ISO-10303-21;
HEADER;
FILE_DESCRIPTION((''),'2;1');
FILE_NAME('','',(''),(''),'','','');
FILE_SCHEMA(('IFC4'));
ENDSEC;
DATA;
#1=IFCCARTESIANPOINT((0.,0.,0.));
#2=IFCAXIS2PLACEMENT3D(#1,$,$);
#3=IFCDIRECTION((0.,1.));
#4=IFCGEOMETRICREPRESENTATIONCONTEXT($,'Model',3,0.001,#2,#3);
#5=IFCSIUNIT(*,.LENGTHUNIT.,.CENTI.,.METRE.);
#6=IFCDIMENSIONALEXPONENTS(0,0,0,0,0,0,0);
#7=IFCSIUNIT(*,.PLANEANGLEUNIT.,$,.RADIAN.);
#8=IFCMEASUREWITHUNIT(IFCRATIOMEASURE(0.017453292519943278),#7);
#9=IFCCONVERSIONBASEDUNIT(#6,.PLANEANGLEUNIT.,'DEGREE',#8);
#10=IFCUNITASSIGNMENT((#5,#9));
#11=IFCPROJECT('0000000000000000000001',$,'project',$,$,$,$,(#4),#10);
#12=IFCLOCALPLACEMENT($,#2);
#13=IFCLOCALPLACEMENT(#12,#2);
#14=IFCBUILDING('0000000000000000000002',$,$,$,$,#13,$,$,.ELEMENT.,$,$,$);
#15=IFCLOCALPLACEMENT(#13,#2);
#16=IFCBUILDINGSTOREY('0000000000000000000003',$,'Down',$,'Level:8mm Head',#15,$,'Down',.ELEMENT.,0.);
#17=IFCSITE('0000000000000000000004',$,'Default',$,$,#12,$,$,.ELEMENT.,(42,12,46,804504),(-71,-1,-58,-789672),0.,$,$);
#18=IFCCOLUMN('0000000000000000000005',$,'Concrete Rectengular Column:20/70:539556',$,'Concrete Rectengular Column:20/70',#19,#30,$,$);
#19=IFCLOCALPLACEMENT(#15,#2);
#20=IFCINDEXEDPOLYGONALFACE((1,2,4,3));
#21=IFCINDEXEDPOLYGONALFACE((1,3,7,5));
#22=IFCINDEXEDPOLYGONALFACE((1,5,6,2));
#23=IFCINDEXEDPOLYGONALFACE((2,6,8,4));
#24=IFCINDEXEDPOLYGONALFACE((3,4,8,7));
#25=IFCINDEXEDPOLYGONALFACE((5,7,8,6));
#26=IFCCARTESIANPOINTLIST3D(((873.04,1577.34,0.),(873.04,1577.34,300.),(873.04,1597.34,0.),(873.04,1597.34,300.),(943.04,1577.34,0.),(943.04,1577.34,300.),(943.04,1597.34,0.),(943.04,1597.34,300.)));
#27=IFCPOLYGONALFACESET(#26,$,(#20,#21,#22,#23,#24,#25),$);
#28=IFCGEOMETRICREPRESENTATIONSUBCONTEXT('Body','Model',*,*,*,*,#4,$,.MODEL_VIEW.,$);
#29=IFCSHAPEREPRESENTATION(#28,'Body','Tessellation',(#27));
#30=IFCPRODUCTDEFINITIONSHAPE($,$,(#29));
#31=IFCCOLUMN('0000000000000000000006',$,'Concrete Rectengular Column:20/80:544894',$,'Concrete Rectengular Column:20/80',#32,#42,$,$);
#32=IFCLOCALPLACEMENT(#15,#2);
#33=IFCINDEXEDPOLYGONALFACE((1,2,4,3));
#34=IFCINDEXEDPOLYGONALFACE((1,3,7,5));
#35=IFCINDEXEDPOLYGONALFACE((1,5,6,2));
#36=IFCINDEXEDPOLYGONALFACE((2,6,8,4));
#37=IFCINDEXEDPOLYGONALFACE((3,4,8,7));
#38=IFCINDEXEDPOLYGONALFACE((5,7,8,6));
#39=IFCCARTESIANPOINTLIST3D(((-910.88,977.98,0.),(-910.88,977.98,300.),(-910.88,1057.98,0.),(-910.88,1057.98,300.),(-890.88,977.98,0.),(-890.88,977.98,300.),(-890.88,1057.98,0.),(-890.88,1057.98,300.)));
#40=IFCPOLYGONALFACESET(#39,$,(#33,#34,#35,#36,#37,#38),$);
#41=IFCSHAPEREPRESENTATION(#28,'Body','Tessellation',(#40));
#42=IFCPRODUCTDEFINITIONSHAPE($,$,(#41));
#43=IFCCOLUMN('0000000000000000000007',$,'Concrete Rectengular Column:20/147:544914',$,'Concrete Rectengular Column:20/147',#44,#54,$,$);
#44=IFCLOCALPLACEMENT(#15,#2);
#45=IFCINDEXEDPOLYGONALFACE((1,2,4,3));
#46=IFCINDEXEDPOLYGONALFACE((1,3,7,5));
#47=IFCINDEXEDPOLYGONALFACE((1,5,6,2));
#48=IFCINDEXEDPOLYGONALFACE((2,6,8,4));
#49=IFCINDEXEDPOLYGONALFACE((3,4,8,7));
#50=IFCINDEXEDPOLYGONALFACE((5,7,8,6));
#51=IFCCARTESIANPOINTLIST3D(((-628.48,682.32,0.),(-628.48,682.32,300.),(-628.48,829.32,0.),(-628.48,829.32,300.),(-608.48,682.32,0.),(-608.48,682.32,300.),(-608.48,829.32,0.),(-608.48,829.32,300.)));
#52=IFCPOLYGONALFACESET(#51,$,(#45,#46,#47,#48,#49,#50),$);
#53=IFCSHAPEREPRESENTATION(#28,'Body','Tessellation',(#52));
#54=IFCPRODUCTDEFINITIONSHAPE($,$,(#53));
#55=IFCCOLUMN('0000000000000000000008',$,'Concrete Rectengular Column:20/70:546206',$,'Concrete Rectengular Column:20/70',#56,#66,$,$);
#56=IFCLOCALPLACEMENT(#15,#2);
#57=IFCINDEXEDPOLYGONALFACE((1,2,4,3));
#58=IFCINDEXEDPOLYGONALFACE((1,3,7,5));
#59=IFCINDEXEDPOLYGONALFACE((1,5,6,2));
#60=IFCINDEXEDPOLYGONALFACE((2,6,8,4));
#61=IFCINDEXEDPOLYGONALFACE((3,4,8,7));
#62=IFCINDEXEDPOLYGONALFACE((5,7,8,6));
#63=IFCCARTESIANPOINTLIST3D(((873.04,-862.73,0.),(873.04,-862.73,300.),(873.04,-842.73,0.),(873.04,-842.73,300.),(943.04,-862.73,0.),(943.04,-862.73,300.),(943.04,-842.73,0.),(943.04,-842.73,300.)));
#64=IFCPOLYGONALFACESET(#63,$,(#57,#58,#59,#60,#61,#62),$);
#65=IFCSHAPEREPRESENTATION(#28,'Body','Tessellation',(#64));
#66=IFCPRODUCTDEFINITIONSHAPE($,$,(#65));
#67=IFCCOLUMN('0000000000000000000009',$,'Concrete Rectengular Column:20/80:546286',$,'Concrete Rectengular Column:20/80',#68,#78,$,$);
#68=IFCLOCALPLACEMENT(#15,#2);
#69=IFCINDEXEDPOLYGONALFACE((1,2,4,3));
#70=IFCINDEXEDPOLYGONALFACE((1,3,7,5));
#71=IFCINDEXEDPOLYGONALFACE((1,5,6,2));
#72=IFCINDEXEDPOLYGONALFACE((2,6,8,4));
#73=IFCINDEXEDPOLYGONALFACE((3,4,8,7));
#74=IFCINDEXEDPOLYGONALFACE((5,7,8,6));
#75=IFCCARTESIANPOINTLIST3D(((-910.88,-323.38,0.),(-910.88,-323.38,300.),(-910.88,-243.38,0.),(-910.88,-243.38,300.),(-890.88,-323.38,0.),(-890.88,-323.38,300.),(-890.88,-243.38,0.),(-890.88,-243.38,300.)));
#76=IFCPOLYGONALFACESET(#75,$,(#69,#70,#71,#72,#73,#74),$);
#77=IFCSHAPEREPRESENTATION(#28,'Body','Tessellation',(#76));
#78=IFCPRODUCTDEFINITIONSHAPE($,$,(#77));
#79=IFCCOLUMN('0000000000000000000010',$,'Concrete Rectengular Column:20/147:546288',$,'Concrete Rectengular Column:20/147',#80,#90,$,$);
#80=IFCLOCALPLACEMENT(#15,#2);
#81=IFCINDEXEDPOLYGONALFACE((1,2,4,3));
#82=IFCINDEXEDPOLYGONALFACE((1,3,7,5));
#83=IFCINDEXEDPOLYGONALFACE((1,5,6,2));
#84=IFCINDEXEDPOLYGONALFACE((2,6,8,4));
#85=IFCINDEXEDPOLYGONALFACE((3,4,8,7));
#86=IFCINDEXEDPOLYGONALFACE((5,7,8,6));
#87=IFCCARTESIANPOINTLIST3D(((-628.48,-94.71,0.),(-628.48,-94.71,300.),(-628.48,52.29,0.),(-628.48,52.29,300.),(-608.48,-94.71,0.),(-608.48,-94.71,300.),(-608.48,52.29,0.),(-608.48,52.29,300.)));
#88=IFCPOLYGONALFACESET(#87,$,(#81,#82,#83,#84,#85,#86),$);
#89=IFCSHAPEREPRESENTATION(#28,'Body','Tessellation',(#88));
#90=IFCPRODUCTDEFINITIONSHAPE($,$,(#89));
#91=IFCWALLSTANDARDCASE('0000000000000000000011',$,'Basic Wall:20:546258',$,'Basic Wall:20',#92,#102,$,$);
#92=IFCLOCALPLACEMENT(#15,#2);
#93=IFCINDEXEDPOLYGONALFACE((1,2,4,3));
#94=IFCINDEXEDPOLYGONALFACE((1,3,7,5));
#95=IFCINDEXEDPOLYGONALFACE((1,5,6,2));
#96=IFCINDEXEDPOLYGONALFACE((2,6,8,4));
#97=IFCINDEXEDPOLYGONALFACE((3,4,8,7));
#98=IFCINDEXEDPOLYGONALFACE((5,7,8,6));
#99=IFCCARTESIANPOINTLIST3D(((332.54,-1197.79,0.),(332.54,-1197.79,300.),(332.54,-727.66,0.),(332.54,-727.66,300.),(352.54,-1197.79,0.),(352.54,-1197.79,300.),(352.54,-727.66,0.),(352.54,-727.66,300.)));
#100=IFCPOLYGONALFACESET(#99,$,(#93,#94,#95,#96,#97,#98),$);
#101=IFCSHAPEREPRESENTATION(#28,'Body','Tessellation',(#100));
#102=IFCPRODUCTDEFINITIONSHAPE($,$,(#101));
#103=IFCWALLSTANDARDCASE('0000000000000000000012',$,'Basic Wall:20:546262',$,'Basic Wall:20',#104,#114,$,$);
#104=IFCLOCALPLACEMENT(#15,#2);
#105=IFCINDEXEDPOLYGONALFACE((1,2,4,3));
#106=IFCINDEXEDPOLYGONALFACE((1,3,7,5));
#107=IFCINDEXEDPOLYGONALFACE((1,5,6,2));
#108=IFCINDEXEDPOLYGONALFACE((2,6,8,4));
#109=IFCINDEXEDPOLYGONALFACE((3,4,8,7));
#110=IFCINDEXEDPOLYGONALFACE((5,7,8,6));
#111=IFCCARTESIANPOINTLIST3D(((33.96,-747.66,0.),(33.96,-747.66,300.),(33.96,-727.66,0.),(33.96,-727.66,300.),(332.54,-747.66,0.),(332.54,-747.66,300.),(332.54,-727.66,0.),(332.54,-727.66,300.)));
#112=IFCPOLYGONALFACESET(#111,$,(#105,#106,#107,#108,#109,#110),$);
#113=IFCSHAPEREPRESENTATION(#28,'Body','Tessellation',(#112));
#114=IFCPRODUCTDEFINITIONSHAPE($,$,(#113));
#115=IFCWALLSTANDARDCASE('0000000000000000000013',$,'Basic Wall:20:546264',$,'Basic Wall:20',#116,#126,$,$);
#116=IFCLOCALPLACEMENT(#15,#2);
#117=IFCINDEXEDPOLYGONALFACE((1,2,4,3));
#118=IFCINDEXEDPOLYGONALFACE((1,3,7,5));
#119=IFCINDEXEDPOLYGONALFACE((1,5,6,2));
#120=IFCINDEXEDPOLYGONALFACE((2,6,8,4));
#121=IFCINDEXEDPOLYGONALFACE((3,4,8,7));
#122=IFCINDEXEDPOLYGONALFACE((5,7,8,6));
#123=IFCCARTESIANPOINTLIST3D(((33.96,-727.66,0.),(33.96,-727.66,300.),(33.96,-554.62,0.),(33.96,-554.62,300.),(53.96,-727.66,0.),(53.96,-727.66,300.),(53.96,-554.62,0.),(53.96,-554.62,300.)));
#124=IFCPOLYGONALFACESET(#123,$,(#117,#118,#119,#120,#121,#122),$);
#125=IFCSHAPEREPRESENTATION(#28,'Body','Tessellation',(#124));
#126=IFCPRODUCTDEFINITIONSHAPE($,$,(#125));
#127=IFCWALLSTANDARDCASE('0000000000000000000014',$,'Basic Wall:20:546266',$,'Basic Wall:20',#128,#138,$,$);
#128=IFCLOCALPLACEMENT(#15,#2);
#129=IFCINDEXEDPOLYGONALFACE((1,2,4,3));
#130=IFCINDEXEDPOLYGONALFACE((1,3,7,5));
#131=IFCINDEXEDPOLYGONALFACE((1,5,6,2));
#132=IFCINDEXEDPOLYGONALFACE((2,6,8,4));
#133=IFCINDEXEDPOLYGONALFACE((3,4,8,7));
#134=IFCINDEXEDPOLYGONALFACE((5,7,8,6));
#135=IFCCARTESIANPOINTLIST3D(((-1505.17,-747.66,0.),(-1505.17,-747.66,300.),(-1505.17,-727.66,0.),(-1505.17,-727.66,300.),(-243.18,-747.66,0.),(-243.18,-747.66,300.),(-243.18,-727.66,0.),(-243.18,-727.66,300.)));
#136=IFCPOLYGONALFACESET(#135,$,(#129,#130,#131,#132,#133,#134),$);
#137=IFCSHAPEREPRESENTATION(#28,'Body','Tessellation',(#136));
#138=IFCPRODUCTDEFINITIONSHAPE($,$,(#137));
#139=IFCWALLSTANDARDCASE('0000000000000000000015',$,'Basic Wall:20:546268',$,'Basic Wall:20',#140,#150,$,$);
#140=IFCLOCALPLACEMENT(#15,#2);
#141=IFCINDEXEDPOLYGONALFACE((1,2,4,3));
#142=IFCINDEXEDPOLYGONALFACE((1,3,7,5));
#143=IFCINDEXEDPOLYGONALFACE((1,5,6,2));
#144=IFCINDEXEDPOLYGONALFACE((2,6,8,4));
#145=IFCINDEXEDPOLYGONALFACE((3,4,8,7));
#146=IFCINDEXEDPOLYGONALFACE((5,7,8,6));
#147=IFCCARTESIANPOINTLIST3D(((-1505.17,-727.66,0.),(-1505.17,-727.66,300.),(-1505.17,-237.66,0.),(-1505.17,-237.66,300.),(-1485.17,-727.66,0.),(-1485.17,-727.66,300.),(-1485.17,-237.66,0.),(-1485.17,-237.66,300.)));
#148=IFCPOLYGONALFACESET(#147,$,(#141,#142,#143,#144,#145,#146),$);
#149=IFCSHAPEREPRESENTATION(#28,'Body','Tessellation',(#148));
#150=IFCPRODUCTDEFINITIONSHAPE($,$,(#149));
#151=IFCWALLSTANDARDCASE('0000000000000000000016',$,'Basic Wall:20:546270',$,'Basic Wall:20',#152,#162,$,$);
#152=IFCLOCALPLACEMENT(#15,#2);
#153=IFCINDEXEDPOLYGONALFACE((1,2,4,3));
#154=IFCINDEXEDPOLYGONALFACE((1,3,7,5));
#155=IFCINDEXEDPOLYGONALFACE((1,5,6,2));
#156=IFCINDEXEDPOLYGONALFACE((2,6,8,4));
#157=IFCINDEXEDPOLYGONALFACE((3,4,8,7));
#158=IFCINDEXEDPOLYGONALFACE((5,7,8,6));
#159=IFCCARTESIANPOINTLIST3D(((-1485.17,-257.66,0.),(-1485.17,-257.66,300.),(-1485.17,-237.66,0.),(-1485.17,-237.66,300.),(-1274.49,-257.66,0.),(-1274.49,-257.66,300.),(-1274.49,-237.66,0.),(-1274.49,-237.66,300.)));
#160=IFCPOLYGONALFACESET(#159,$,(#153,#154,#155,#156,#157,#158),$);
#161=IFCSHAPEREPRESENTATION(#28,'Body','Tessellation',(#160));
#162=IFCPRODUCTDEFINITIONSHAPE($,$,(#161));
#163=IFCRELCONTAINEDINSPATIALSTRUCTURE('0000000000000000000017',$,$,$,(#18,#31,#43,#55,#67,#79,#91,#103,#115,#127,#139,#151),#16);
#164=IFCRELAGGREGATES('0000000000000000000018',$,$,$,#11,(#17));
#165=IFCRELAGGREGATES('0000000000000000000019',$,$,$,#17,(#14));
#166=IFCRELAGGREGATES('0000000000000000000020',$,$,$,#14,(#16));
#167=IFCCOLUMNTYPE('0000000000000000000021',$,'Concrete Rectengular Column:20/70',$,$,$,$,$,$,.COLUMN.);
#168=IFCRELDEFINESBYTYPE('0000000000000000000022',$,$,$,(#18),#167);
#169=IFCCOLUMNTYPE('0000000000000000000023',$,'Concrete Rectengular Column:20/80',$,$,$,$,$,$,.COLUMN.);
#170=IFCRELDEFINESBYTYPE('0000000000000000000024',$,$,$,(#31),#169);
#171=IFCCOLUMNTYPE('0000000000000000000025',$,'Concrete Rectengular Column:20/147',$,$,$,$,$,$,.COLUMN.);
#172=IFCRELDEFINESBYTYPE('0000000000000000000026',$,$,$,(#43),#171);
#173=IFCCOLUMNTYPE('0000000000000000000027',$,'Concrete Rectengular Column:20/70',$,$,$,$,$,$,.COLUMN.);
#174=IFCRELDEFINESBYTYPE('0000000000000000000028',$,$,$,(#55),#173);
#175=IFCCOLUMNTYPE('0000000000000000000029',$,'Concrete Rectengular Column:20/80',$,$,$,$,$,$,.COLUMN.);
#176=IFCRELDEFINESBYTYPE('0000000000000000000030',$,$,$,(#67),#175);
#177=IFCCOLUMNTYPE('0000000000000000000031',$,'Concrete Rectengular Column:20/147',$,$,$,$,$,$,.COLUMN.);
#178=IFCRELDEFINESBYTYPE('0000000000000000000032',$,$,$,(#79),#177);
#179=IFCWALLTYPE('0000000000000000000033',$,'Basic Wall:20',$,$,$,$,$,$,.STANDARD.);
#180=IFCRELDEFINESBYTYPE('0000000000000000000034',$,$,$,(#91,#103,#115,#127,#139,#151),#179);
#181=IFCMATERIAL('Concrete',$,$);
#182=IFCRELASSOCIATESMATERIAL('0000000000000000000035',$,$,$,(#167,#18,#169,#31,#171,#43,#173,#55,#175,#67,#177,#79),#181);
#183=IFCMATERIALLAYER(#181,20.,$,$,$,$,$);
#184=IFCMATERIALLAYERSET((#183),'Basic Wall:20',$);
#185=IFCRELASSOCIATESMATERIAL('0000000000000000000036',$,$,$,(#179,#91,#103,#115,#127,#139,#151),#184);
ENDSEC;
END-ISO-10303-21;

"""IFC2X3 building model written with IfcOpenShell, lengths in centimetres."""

from ifc_helpers import new_model, entity, si_unit, converted_unit, direction, frame, frame_2d, origin, origin_2d_with_axis, place, context, subcontext, project, spatial, polyline, rectangle, extrude, clip, bounded_halfspace, source, transform, mapped, material, layer, layer_set, layer_usage, type_object, type_shapes, element, save


model = new_model("IFC2X3")

# Units and contexts
model_context = context("Model", 3, precision=0.001, world=origin(), true_north=direction((0.0, 1.0)))
body_context = subcontext(model_context, "Body", "Model", "MODEL_VIEW")
ifc_project = project(units=[si_unit("LENGTHUNIT", "METRE", prefix="CENTI"), converted_unit("PLANEANGLEUNIT", "DEGREE", entity("IfcRatioMeasure", 0.017453292519943278), si_unit("PLANEANGLEUNIT", "RADIAN"), dimensions=[0, 0, 0, 0, 0, 0, 0])], contexts=[model_context])

# Site, building, storey
site_placement = place(None, origin())
site = spatial("IfcSite", under=ifc_project, at=site_placement, Name="Default", CompositionType="ELEMENT", RefLatitude=(42, 12, 46, 804504), RefLongitude=(-71, -1, -58, -789672), RefElevation=0.0)
building_placement = place(site_placement, origin())
building = spatial("IfcBuilding", under=site, at=building_placement, CompositionType="ELEMENT")
storey_placement = place(building_placement, origin())
storey = spatial("IfcBuildingStorey", under=building, at=storey_placement, Name="Down", ObjectType="Level:8mm Head", LongName="Down", CompositionType="ELEMENT", Elevation=0.0)

# Columns
ifc_material = material(Name="Concrete")
column_type_1 = type_object("IfcColumnType", Name="Concrete Rectengular Column:20/70", PredefinedType="COLUMN", material=ifc_material)
shared_shape_1 = source(origin(), body_context, "Body", "SweptSolid", [
    extrude(rectangle(XDim=20.0, YDim=70.0, at=frame_2d((0.0, 0.0), x_axis=(1.0, 0.0))), frame((908.04, 1587.34, 0.0), z_axis=(0.0, 0.0, 1.0), x_axis=(0.0, -1.0, 0.0)), (0.0, 0.0, 1.0), 300.0),
])
type_shapes(column_type_1, [shared_shape_1])
column_1_placement = place(storey_placement, origin())
element("IfcColumn", 1, at=column_1_placement, inside=storey, type_object=column_type_1, material=ifc_material, Name="Concrete Rectengular Column:20/70:539556", ObjectType="Concrete Rectengular Column:20/70", context=body_context, shape_type="MappedRepresentation", body=[
    mapped(shared_shape_1, transform((0.0, 0.0, 0.0), scale=1.0)),
])
column_type_2 = type_object("IfcColumnType", Name="Concrete Rectengular Column:20/80", PredefinedType="COLUMN", material=ifc_material)
shared_shape_2 = source(origin(), body_context, "Body", "SweptSolid", [
    extrude(rectangle(XDim=80.0, YDim=20.0, at=origin_2d_with_axis()), frame((-900.88, 1017.98, 0.0), z_axis=(0.0, 0.0, 1.0), x_axis=(0.0, -1.0, 0.0)), (0.0, 0.0, 1.0), 300.0),
])
type_shapes(column_type_2, [shared_shape_2])
column_2_placement = place(storey_placement, origin())
element("IfcColumn", 2, at=column_2_placement, inside=storey, type_object=column_type_2, material=ifc_material, Name="Concrete Rectengular Column:20/80:544894", ObjectType="Concrete Rectengular Column:20/80", context=body_context, shape_type="MappedRepresentation", body=[
    mapped(shared_shape_2, transform((0.0, 0.0, 0.0), scale=1.0)),
])
column_type_3 = type_object("IfcColumnType", Name="Concrete Rectengular Column:20/147", PredefinedType="COLUMN", material=ifc_material)
shared_shape_3 = source(origin(), body_context, "Body", "SweptSolid", [
    extrude(rectangle(XDim=147.0, YDim=20.0, at=origin_2d_with_axis()), frame((-618.48, 755.82, 0.0), z_axis=(0.0, 0.0, 1.0), x_axis=(0.0, -1.0, 0.0)), (0.0, 0.0, 1.0), 300.0),
])
type_shapes(column_type_3, [shared_shape_3])
column_3_placement = place(storey_placement, origin())
element("IfcColumn", 3, at=column_3_placement, inside=storey, type_object=column_type_3, material=ifc_material, Name="Concrete Rectengular Column:20/147:544914", ObjectType="Concrete Rectengular Column:20/147", context=body_context, shape_type="MappedRepresentation", body=[
    mapped(shared_shape_3, transform((0.0, 0.0, 0.0), scale=1.0)),
])
column_type_4 = type_object("IfcColumnType", Name="Concrete Rectengular Column:20/70", PredefinedType="COLUMN", material=ifc_material)
shared_shape_4 = source(origin(), body_context, "Body", "SweptSolid", [
    extrude(rectangle(XDim=20.0, YDim=70.0, at=frame_2d((0.0, 0.0), x_axis=(1.0, 0.0))), frame((908.04, -852.73, 0.0), z_axis=(0.0, 0.0, 1.0), x_axis=(0.0, -1.0, 0.0)), (0.0, 0.0, 1.0), 300.0),
])
type_shapes(column_type_4, [shared_shape_4])
column_4_placement = place(storey_placement, origin())
element("IfcColumn", 4, at=column_4_placement, inside=storey, type_object=column_type_4, material=ifc_material, Name="Concrete Rectengular Column:20/70:546206", ObjectType="Concrete Rectengular Column:20/70", context=body_context, shape_type="MappedRepresentation", body=[
    mapped(shared_shape_4, transform((0.0, 0.0, 0.0), scale=1.0)),
])
column_type_5 = type_object("IfcColumnType", Name="Concrete Rectengular Column:20/80", PredefinedType="COLUMN", material=ifc_material)
shared_shape_5 = source(origin(), body_context, "Body", "SweptSolid", [
    extrude(rectangle(XDim=80.0, YDim=20.0, at=origin_2d_with_axis()), frame((-900.88, -283.38, 0.0), z_axis=(0.0, 0.0, 1.0), x_axis=(0.0, -1.0, 0.0)), (0.0, 0.0, 1.0), 300.0),
])
type_shapes(column_type_5, [shared_shape_5])
column_5_placement = place(storey_placement, origin())
element("IfcColumn", 5, at=column_5_placement, inside=storey, type_object=column_type_5, material=ifc_material, Name="Concrete Rectengular Column:20/80:546286", ObjectType="Concrete Rectengular Column:20/80", context=body_context, shape_type="MappedRepresentation", body=[
    mapped(shared_shape_5, transform((0.0, 0.0, 0.0), scale=1.0)),
])
column_type_6 = type_object("IfcColumnType", Name="Concrete Rectengular Column:20/147", PredefinedType="COLUMN", material=ifc_material)
shared_shape_6 = source(origin(), body_context, "Body", "SweptSolid", [
    extrude(rectangle(XDim=147.0, YDim=20.0, at=frame_2d((0.0, 0.0), x_axis=(1.0, 0.0))), frame((-618.48, -21.21, 0.0), z_axis=(0.0, 0.0, 1.0), x_axis=(0.0, -1.0, 0.0)), (0.0, 0.0, 1.0), 300.0),
])
type_shapes(column_type_6, [shared_shape_6])
column_6_placement = place(storey_placement, origin())
element("IfcColumn", 6, at=column_6_placement, inside=storey, type_object=column_type_6, material=ifc_material, Name="Concrete Rectengular Column:20/147:546288", ObjectType="Concrete Rectengular Column:20/147", context=body_context, shape_type="MappedRepresentation", body=[
    mapped(shared_shape_6, transform((0.0, 0.0, 0.0), scale=1.0)),
])

# Walls
ifc_layer_1 = layer(ifc_material, 20.0)
ifc_layer_set_1 = layer_set([ifc_layer_1], Name="Basic Wall:20")
ifc_layer_usage_1 = layer_usage(ifc_layer_set_1, "AXIS2", "NEGATIVE", 10.0)
wall_type_1 = type_object("IfcWallType", Name="Basic Wall:20", PredefinedType="STANDARD", material=ifc_layer_set_1)
wall_1_placement = place(storey_placement, frame((342.54, -1197.79, 0.0), z_axis=(0.0, 0.0, 1.0), x_axis=(0.0, 1.0, 0.0)))
element("IfcWallStandardCase", 7, at=wall_1_placement, inside=storey, type_object=wall_type_1, material=ifc_layer_usage_1, Name="Basic Wall:20:546258", ObjectType="Basic Wall:20", context=body_context, shape_type="SweptSolid", body=[
    extrude(rectangle(XDim=470.13, YDim=20.0, at=frame_2d((235.07, 0.0), x_axis=(-1.0, 0.0))), origin(), (0.0, 0.0, 1.0), 300.0),
])
ifc_layer_usage_2 = layer_usage(ifc_layer_set_1, "AXIS2", "NEGATIVE", 10.0)
wall_2_placement = place(storey_placement, frame((332.54, -737.66, 0.0), z_axis=(0.0, 0.0, 1.0), x_axis=(-1.0, 0.0, 0.0)))
element("IfcWallStandardCase", 8, at=wall_2_placement, inside=storey, type_object=wall_type_1, material=ifc_layer_usage_2, Name="Basic Wall:20:546262", ObjectType="Basic Wall:20", context=body_context, shape_type="SweptSolid", body=[
    extrude(rectangle(XDim=298.58, YDim=20.0, at=frame_2d((149.29, 0.0), x_axis=(-1.0, 0.0))), origin(), (0.0, 0.0, 1.0), 300.0),
])
ifc_layer_usage_3 = layer_usage(ifc_layer_set_1, "AXIS2", "NEGATIVE", 10.0)
wall_3_placement = place(storey_placement, frame((43.96, -727.66, 0.0), z_axis=(0.0, 0.0, 1.0), x_axis=(0.0, 1.0, 0.0)))
element("IfcWallStandardCase", 9, at=wall_3_placement, inside=storey, type_object=wall_type_1, material=ifc_layer_usage_3, Name="Basic Wall:20:546264", ObjectType="Basic Wall:20", context=body_context, shape_type="SweptSolid", body=[
    extrude(rectangle(XDim=173.03, YDim=20.0, at=frame_2d((86.52, 0.0), x_axis=(-1.0, 0.0))), origin(), (0.0, 0.0, 1.0), 300.0),
])
ifc_layer_usage_4 = layer_usage(ifc_layer_set_1, "AXIS2", "NEGATIVE", 10.0)
wall_4_placement = place(storey_placement, frame((-243.18, -737.66, 0.0), z_axis=(0.0, 0.0, 1.0), x_axis=(-1.0, 0.0, 0.0)))
element("IfcWallStandardCase", 10, at=wall_4_placement, inside=storey, type_object=wall_type_1, material=ifc_layer_usage_4, Name="Basic Wall:20:546266", ObjectType="Basic Wall:20", context=body_context, shape_type="SweptSolid", body=[
    extrude(rectangle(XDim=1261.99, YDim=20.0, at=frame_2d((631.0, 0.0), x_axis=(-1.0, 0.0))), origin(), (0.0, 0.0, 1.0), 300.0),
])
ifc_layer_usage_5 = layer_usage(ifc_layer_set_1, "AXIS2", "NEGATIVE", 10.0)
wall_5_placement = place(storey_placement, frame((-1495.17, -727.66, 0.0), z_axis=(0.0, 0.0, 1.0), x_axis=(0.0, 1.0, 0.0)))
element("IfcWallStandardCase", 11, at=wall_5_placement, inside=storey, type_object=wall_type_1, material=ifc_layer_usage_5, Name="Basic Wall:20:546268", ObjectType="Basic Wall:20", context=body_context, shape_type="SweptSolid", body=[
    extrude(rectangle(XDim=490.0, YDim=20.0, at=frame_2d((245.0, 0.0), x_axis=(-1.0, 0.0))), origin(), (0.0, 0.0, 1.0), 300.0),
])
ifc_layer_usage_6 = layer_usage(ifc_layer_set_1, "AXIS2", "NEGATIVE", 10.0)
wall_6_placement = place(storey_placement, frame((-1485.17, -247.66, 0.0)))
element("IfcWallStandardCase", 12, at=wall_6_placement, inside=storey, type_object=wall_type_1, material=ifc_layer_usage_6, Name="Basic Wall:20:546270", ObjectType="Basic Wall:20", context=body_context, shape_type="Clipping", body=[
    clip(extrude(rectangle(XDim=210.68, YDim=20.0, at=frame_2d((105.34, 0.0), x_axis=(-1.0, 0.0))), origin(), (0.0, 0.0, 1.0), 300.0), bounded_halfspace(frame((210.68, -10.0, 300.0), z_axis=(-1.0, 0.0, 0.0), x_axis=(0.0, -1.0, 0.0)), True, frame((210.68, -10.0, 300.0), z_axis=(-1.0, 0.0, 0.0), x_axis=(0.0, -1.0, 0.0)), polyline([(0.0, 0.0), (-20.0, 0.0), (-20.0, -300.0), (0.0, -300.0), (0.0, -20.0), (0.0, 0.0)]))),
])

save(model, "model.ifc")
